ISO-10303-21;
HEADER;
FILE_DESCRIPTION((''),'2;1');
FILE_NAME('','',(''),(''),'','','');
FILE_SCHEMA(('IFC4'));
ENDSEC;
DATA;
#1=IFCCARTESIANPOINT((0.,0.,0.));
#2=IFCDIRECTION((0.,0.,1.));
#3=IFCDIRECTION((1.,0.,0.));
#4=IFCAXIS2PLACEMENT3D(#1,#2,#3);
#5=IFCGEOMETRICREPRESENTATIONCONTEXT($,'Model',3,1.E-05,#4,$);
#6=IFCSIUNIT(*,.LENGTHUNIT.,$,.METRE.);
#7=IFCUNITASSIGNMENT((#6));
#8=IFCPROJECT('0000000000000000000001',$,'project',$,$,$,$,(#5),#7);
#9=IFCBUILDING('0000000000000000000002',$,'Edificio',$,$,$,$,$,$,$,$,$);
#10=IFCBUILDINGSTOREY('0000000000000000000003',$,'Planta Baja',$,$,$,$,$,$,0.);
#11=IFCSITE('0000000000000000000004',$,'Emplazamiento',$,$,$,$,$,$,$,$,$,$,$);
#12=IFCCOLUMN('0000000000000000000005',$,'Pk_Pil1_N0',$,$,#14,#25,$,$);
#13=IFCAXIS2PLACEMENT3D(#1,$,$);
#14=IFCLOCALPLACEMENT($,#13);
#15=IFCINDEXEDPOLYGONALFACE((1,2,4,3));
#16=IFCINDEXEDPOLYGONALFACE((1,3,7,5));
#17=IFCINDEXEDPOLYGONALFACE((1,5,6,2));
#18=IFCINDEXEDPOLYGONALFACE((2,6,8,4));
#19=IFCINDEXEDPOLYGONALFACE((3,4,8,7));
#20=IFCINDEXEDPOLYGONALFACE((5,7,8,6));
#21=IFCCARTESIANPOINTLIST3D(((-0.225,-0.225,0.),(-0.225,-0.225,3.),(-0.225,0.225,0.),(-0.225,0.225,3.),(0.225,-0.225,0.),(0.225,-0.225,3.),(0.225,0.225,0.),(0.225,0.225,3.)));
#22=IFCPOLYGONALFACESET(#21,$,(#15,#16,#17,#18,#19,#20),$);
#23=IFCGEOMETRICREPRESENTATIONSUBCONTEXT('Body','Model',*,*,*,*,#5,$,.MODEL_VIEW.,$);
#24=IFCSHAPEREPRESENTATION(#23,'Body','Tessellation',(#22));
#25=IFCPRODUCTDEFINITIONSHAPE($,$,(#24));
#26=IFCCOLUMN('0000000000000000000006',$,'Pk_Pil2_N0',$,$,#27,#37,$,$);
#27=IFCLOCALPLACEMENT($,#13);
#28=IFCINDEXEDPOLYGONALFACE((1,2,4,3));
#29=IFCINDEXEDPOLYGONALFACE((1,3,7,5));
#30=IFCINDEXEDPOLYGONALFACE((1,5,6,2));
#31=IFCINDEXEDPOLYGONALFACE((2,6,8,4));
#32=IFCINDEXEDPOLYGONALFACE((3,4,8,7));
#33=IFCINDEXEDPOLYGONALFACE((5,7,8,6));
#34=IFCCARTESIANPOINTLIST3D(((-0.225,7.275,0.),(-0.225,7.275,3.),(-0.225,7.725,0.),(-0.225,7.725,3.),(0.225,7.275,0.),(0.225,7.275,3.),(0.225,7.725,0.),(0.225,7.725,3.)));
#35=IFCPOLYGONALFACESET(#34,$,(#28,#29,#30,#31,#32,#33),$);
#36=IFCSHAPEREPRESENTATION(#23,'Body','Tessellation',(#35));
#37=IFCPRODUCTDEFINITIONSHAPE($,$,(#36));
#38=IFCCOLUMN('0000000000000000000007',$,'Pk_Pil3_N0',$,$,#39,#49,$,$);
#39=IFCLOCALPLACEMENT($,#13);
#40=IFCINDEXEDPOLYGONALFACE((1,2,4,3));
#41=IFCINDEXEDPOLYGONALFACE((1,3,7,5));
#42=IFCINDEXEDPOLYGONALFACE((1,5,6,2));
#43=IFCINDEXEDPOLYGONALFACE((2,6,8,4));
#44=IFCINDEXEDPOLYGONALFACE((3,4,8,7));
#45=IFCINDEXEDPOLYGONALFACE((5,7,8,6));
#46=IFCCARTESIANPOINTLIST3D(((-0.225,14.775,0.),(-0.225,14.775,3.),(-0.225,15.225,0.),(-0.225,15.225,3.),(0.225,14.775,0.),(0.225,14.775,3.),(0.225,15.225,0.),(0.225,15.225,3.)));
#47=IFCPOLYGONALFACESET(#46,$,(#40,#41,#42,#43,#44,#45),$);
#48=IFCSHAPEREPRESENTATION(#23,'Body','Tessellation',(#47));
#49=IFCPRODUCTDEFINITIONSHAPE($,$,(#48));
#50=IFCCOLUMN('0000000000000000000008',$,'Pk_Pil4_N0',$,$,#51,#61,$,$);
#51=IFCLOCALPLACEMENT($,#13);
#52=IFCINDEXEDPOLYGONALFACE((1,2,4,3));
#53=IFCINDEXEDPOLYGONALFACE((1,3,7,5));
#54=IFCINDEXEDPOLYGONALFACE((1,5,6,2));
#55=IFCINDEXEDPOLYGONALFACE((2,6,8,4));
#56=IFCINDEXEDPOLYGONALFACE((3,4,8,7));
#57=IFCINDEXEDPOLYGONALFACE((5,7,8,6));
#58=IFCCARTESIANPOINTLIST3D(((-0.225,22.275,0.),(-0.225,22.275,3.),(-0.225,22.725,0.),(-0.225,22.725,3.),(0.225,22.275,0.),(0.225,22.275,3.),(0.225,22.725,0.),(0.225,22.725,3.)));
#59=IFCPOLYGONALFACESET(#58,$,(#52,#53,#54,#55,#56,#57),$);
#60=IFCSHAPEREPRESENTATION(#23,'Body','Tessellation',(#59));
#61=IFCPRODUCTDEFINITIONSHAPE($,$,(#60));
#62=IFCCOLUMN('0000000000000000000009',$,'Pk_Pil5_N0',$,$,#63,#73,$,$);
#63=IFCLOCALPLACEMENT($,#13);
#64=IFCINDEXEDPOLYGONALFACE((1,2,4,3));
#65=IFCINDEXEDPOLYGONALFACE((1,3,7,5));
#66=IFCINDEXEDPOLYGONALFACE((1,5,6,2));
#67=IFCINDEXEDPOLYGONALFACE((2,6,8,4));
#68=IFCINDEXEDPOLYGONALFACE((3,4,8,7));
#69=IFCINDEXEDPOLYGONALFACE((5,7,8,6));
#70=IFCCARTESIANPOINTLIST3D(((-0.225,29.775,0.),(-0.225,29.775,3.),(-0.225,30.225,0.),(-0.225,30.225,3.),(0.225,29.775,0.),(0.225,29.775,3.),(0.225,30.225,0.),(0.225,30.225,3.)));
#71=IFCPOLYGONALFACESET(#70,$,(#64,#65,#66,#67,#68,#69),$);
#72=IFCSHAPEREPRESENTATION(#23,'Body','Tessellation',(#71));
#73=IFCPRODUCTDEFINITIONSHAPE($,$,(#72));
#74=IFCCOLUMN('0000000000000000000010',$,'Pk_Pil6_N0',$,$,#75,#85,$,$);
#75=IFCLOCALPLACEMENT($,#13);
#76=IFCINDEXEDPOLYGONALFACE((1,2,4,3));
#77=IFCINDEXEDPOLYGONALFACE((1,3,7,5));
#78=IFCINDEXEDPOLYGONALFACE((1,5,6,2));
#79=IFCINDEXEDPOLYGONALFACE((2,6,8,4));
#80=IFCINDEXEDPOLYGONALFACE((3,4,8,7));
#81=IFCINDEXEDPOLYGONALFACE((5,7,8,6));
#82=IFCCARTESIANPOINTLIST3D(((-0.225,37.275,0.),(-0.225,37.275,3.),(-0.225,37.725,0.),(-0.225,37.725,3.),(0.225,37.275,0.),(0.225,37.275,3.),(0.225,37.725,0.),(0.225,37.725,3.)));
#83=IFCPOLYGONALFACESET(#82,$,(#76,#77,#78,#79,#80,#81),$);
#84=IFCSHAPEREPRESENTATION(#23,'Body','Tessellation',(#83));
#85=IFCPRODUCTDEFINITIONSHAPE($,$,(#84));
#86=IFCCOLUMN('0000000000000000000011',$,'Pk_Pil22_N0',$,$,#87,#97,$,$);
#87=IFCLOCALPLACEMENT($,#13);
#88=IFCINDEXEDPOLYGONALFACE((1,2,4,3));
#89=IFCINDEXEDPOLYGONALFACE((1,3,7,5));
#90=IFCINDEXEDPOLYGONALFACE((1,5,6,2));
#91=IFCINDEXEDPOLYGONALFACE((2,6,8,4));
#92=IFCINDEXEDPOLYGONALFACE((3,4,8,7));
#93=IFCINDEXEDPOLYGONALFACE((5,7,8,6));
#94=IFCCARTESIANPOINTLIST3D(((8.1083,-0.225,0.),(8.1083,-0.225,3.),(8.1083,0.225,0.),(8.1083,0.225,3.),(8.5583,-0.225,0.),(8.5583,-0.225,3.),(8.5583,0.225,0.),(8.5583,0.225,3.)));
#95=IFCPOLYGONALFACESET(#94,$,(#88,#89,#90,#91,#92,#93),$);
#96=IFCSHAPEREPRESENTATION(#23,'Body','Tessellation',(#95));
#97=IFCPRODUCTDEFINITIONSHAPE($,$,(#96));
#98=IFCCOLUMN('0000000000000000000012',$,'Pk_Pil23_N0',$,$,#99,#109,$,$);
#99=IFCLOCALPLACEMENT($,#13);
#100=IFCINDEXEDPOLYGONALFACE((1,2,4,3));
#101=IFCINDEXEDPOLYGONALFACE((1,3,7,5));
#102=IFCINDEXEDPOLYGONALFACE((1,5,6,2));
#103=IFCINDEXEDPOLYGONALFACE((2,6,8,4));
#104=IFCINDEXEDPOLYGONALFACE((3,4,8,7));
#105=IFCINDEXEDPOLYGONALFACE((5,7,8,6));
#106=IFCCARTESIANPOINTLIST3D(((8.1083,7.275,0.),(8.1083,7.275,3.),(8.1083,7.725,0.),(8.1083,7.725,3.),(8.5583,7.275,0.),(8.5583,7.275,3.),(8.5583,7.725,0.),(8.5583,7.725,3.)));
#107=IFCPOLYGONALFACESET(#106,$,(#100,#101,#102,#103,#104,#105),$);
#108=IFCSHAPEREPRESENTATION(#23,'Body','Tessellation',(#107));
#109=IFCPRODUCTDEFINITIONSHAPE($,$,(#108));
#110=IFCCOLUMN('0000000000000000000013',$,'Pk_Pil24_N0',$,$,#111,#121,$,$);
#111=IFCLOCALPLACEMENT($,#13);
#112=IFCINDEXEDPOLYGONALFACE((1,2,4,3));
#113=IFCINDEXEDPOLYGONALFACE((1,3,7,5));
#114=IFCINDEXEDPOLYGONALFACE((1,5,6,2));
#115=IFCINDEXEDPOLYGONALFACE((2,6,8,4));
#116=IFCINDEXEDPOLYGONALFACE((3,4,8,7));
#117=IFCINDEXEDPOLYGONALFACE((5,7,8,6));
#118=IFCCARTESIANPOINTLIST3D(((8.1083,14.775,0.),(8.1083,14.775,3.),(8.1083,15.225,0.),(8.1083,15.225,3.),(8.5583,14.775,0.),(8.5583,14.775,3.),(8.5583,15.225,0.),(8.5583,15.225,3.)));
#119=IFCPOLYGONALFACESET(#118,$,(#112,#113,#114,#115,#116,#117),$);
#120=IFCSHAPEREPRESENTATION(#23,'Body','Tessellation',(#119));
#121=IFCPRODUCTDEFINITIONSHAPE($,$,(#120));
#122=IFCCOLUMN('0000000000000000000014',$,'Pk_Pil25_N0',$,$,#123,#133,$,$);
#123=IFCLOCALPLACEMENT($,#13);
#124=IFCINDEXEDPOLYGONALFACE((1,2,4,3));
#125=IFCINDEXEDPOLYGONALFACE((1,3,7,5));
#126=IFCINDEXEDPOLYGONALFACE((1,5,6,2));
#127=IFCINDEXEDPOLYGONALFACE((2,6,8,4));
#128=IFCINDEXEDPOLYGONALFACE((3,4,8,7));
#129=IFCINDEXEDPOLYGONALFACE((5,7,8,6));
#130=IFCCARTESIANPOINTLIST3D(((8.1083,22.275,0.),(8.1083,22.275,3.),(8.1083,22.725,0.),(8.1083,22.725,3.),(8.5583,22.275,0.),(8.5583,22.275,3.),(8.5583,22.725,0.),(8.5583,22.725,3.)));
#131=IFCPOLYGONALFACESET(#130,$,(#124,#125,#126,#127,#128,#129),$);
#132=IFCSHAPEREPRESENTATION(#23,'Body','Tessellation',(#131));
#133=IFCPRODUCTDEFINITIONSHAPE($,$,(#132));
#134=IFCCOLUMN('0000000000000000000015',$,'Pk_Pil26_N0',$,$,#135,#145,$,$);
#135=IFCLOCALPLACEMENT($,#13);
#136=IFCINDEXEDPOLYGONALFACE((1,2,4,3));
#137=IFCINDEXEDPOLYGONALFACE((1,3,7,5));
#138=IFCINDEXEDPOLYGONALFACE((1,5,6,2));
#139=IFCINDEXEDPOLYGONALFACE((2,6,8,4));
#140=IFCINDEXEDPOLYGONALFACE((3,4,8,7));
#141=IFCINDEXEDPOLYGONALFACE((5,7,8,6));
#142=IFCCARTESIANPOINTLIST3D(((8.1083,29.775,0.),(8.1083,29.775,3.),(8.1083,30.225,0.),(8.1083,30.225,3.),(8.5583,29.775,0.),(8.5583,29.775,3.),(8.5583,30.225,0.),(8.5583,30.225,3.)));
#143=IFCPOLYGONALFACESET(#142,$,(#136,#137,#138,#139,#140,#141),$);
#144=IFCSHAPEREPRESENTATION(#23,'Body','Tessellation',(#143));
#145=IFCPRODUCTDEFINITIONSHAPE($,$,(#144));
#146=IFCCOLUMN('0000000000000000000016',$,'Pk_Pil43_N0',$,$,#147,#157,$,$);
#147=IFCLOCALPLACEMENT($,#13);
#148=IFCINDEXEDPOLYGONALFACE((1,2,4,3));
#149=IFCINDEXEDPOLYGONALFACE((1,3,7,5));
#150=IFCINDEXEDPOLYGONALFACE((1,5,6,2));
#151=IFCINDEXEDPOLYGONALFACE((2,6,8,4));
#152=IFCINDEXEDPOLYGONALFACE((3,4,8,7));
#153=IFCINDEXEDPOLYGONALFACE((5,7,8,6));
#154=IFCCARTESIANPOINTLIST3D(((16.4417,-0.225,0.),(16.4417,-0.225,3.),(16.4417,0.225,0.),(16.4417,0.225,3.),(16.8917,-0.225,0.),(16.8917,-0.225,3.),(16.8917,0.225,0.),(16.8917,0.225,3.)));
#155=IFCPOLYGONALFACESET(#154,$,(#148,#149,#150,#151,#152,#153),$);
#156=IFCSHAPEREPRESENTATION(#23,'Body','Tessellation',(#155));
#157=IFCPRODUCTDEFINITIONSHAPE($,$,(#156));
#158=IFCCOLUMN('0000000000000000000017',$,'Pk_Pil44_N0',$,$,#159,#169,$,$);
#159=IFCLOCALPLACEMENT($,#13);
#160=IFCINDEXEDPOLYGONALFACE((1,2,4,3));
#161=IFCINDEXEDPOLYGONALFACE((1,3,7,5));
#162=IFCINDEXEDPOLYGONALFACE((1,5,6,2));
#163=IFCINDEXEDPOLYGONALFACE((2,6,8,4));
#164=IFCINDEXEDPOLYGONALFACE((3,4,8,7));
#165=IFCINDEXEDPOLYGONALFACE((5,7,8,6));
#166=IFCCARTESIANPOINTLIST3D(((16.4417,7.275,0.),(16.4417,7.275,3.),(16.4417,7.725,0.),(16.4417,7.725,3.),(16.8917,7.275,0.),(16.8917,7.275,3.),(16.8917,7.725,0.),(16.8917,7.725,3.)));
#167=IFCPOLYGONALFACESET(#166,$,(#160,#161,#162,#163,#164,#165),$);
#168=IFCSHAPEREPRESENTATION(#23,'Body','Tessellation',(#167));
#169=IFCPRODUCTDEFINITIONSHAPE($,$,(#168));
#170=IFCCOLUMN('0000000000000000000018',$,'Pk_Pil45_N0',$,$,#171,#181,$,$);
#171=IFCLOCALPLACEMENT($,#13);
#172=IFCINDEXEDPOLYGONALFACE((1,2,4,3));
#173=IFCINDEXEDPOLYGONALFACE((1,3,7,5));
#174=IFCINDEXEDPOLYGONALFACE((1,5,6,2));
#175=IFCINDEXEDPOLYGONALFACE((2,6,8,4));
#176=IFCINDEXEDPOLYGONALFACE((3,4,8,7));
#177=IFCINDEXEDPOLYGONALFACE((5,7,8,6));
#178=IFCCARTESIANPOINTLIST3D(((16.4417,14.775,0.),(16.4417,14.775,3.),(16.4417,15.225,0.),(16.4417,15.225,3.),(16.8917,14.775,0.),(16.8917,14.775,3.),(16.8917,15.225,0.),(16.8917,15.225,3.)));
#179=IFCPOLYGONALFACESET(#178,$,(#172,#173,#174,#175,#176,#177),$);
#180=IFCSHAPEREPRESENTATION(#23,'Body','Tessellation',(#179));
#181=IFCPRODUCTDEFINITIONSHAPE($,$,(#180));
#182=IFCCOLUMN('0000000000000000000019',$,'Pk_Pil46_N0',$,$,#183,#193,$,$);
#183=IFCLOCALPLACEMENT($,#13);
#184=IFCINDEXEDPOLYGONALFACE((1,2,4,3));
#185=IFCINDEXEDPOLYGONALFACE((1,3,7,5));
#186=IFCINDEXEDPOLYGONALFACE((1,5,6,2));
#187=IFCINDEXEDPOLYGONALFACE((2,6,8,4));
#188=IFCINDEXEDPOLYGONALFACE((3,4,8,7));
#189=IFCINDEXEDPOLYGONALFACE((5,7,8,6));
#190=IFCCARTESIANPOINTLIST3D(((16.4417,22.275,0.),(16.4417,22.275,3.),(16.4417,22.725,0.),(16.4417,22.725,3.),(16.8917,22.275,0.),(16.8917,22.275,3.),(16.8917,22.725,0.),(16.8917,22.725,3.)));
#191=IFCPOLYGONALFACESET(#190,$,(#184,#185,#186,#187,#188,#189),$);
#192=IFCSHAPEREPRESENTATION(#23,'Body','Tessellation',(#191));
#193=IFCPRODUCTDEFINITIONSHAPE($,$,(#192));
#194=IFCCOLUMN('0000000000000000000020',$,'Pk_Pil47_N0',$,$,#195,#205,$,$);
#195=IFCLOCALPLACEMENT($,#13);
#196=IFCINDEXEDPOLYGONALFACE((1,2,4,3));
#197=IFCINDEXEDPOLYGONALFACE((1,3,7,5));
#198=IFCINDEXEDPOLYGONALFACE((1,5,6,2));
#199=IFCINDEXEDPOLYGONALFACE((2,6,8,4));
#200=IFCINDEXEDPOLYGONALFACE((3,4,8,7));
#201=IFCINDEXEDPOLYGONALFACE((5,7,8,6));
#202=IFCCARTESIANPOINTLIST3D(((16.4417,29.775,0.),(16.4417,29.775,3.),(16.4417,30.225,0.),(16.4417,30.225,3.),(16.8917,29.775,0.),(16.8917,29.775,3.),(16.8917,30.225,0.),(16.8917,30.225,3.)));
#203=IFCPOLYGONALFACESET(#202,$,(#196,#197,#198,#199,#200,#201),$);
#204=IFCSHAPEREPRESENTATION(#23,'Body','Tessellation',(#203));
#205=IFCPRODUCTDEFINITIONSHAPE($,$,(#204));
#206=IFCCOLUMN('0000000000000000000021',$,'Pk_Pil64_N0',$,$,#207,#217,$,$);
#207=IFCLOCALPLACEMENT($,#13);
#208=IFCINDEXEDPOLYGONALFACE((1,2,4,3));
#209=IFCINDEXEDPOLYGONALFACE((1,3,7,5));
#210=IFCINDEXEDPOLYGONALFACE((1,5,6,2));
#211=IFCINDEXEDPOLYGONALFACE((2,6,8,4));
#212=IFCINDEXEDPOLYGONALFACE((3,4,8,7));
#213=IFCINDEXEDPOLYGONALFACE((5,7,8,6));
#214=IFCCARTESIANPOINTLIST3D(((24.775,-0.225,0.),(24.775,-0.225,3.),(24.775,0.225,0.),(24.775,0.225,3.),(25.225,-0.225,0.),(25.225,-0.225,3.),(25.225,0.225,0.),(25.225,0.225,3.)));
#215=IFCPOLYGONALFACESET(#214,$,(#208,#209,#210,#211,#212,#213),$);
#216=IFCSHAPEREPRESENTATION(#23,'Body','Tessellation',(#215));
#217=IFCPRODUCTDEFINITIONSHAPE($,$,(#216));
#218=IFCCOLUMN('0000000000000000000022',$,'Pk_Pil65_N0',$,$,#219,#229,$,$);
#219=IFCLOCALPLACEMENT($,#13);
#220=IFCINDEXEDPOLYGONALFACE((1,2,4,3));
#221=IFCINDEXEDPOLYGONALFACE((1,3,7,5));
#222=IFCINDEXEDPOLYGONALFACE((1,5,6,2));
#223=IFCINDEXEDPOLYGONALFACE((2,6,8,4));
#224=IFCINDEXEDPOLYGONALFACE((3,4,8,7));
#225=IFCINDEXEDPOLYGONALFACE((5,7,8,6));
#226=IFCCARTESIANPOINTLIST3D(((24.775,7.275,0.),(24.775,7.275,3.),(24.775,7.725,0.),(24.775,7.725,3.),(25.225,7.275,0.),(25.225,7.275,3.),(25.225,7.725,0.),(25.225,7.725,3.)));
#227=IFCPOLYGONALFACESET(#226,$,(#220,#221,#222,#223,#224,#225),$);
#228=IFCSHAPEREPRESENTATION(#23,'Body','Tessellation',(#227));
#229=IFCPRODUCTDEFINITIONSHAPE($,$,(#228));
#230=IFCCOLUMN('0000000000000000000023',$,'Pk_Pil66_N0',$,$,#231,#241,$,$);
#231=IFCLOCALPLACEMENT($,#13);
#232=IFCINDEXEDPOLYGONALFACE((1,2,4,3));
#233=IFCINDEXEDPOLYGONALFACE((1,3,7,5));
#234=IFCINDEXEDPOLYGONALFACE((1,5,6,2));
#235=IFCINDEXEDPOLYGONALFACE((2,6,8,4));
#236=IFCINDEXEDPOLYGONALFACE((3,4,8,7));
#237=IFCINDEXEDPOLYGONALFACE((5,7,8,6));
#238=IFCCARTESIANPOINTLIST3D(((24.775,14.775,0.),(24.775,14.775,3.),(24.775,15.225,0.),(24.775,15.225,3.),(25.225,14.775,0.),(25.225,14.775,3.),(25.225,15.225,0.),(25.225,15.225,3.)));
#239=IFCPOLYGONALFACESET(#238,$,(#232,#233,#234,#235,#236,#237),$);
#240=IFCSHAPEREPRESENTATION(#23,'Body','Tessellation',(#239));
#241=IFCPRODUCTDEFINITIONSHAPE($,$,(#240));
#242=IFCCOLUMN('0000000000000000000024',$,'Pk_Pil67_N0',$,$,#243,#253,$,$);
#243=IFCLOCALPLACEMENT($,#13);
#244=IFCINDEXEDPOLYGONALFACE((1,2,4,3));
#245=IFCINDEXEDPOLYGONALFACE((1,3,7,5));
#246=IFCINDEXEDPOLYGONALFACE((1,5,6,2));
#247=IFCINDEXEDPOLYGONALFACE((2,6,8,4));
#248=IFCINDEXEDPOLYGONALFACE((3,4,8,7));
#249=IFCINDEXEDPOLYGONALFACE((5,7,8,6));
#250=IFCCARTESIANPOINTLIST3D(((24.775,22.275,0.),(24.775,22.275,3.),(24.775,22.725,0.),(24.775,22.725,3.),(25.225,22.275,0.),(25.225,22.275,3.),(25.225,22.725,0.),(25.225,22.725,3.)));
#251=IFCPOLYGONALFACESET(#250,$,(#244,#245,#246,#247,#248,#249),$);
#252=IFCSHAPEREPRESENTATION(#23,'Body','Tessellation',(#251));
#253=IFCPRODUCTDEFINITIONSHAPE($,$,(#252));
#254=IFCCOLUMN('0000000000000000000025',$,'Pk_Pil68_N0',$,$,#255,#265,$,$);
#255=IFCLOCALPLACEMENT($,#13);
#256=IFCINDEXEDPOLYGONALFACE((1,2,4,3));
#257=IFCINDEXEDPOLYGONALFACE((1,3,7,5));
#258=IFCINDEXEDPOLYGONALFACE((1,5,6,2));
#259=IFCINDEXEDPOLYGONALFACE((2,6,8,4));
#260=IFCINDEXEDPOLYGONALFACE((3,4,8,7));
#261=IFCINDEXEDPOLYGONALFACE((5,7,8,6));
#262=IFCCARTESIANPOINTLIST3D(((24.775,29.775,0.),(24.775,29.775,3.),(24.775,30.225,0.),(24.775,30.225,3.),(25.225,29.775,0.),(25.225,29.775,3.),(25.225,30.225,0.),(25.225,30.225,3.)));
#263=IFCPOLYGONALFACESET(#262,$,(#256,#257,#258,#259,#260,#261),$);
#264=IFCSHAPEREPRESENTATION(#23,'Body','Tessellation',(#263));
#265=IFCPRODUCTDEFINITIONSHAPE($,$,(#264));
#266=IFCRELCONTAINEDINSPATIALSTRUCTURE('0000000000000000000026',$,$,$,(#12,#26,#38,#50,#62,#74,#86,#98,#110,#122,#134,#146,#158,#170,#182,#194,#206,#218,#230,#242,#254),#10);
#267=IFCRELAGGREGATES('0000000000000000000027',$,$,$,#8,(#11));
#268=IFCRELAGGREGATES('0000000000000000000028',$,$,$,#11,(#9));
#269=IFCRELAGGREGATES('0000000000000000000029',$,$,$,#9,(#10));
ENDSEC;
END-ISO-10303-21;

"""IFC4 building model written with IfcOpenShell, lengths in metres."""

from ifc_helpers import new_model, si_unit, frame, origin_with_axes, origin_2d, place, context, subcontext, project, spatial, rectangle, extrude, element, save


model = new_model("IFC4")

# Units and contexts
model_context = context("Model", 3, precision=1e-05, world=origin_with_axes())
body_context = subcontext(model_context, "Body", "Model", "MODEL_VIEW")
ifc_project = project(units=[si_unit("LENGTHUNIT", "METRE")], contexts=[model_context])

# Site, building, storey
site = spatial("IfcSite", under=ifc_project, Name="Emplazamiento")
building = spatial("IfcBuilding", under=site, Name="Edificio")
storey = spatial("IfcBuildingStorey", under=building, Name="Planta Baja", Elevation=0.0)

# Columns
for number, where, z_axis, x_axis, name in (
    (1, (0.0, 0.0, 0.0), (0.0, 0.0, 1.0), (1.0, 0.0, 0.0), "Pk_Pil1_N0"),
    (2, (0.0, 7.5, 0.0), (0.0, 0.0, 1.0), (1.0, 0.0, 0.0), "Pk_Pil2_N0"),
    (3, (0.0, 15.0, 0.0), (0.0, 0.0, 1.0), (1.0, 0.0, 0.0), "Pk_Pil3_N0"),
    (4, (0.0, 22.5, 0.0), (0.0, 0.0, 1.0), (1.0, 0.0, 0.0), "Pk_Pil4_N0"),
    (5, (0.0, 30.0, 0.0), (0.0, 0.0, 1.0), (1.0, 0.0, 0.0), "Pk_Pil5_N0"),
    (6, (0.0, 37.5, 0.0), (0.0, 0.0, 1.0), (1.0, 0.0, 0.0), "Pk_Pil6_N0"),
    (7, (8.3333, 0.0, 0.0), (0.0, 0.0, 1.0), (1.0, 0.0, 0.0), "Pk_Pil22_N0"),
    (8, (8.3333, 7.5, 0.0), (0.0, 0.0, 1.0), (1.0, 0.0, 0.0), "Pk_Pil23_N0"),
    (9, (8.3333, 15.0, 0.0), (0.0, 0.0, 1.0), (1.0, 0.0, 0.0), "Pk_Pil24_N0"),
    (10, (8.3333, 22.5, 0.0), (0.0, 0.0, 1.0), (1.0, 0.0, 0.0), "Pk_Pil25_N0"),
    (11, (8.3333, 30.0, 0.0), (0.0, 0.0, 1.0), (1.0, 0.0, 0.0), "Pk_Pil26_N0"),
    (12, (16.6667, 0.0, 0.0), (0.0, 0.0, 1.0), (1.0, 0.0, 0.0), "Pk_Pil43_N0"),
    (13, (16.6667, 7.5, 0.0), (0.0, 0.0, 1.0), (1.0, 0.0, 0.0), "Pk_Pil44_N0"),
    (14, (16.6667, 15.0, 0.0), (0.0, 0.0, 1.0), (1.0, 0.0, 0.0), "Pk_Pil45_N0"),
    (15, (16.6667, 22.5, 0.0), (0.0, 0.0, 1.0), (1.0, 0.0, 0.0), "Pk_Pil46_N0"),
    (16, (16.6667, 30.0, 0.0), (0.0, 0.0, 1.0), (1.0, 0.0, 0.0), "Pk_Pil47_N0"),
    (17, (25.0, 0.0, 0.0), (0.0, 0.0, 1.0), (1.0, 0.0, 0.0), "Pk_Pil64_N0"),
    (18, (25.0, 7.5, 0.0), (0.0, 0.0, 1.0), (1.0, 0.0, 0.0), "Pk_Pil65_N0"),
    (19, (25.0, 15.0, 0.0), (0.0, 0.0, 1.0), (1.0, 0.0, 0.0), "Pk_Pil66_N0"),
    (20, (25.0, 22.5, 0.0), (0.0, 0.0, 1.0), (1.0, 0.0, 0.0), "Pk_Pil67_N0"),
    (21, (25.0, 30.0, 0.0), (0.0, 0.0, 1.0), (1.0, 0.0, 0.0), "Pk_Pil68_N0"),
):
    element("IfcColumn", number, at=place(None, frame(where, z_axis=z_axis, x_axis=x_axis)), inside=storey, Name=name, context=body_context, shape_type="SweptSolid", body=[
        extrude(rectangle(XDim=0.45, YDim=0.45, at=origin_2d()), origin_with_axes(), (0.0, 0.0, 1.0), 3.0),
    ])

save(model, "model.ifc")
